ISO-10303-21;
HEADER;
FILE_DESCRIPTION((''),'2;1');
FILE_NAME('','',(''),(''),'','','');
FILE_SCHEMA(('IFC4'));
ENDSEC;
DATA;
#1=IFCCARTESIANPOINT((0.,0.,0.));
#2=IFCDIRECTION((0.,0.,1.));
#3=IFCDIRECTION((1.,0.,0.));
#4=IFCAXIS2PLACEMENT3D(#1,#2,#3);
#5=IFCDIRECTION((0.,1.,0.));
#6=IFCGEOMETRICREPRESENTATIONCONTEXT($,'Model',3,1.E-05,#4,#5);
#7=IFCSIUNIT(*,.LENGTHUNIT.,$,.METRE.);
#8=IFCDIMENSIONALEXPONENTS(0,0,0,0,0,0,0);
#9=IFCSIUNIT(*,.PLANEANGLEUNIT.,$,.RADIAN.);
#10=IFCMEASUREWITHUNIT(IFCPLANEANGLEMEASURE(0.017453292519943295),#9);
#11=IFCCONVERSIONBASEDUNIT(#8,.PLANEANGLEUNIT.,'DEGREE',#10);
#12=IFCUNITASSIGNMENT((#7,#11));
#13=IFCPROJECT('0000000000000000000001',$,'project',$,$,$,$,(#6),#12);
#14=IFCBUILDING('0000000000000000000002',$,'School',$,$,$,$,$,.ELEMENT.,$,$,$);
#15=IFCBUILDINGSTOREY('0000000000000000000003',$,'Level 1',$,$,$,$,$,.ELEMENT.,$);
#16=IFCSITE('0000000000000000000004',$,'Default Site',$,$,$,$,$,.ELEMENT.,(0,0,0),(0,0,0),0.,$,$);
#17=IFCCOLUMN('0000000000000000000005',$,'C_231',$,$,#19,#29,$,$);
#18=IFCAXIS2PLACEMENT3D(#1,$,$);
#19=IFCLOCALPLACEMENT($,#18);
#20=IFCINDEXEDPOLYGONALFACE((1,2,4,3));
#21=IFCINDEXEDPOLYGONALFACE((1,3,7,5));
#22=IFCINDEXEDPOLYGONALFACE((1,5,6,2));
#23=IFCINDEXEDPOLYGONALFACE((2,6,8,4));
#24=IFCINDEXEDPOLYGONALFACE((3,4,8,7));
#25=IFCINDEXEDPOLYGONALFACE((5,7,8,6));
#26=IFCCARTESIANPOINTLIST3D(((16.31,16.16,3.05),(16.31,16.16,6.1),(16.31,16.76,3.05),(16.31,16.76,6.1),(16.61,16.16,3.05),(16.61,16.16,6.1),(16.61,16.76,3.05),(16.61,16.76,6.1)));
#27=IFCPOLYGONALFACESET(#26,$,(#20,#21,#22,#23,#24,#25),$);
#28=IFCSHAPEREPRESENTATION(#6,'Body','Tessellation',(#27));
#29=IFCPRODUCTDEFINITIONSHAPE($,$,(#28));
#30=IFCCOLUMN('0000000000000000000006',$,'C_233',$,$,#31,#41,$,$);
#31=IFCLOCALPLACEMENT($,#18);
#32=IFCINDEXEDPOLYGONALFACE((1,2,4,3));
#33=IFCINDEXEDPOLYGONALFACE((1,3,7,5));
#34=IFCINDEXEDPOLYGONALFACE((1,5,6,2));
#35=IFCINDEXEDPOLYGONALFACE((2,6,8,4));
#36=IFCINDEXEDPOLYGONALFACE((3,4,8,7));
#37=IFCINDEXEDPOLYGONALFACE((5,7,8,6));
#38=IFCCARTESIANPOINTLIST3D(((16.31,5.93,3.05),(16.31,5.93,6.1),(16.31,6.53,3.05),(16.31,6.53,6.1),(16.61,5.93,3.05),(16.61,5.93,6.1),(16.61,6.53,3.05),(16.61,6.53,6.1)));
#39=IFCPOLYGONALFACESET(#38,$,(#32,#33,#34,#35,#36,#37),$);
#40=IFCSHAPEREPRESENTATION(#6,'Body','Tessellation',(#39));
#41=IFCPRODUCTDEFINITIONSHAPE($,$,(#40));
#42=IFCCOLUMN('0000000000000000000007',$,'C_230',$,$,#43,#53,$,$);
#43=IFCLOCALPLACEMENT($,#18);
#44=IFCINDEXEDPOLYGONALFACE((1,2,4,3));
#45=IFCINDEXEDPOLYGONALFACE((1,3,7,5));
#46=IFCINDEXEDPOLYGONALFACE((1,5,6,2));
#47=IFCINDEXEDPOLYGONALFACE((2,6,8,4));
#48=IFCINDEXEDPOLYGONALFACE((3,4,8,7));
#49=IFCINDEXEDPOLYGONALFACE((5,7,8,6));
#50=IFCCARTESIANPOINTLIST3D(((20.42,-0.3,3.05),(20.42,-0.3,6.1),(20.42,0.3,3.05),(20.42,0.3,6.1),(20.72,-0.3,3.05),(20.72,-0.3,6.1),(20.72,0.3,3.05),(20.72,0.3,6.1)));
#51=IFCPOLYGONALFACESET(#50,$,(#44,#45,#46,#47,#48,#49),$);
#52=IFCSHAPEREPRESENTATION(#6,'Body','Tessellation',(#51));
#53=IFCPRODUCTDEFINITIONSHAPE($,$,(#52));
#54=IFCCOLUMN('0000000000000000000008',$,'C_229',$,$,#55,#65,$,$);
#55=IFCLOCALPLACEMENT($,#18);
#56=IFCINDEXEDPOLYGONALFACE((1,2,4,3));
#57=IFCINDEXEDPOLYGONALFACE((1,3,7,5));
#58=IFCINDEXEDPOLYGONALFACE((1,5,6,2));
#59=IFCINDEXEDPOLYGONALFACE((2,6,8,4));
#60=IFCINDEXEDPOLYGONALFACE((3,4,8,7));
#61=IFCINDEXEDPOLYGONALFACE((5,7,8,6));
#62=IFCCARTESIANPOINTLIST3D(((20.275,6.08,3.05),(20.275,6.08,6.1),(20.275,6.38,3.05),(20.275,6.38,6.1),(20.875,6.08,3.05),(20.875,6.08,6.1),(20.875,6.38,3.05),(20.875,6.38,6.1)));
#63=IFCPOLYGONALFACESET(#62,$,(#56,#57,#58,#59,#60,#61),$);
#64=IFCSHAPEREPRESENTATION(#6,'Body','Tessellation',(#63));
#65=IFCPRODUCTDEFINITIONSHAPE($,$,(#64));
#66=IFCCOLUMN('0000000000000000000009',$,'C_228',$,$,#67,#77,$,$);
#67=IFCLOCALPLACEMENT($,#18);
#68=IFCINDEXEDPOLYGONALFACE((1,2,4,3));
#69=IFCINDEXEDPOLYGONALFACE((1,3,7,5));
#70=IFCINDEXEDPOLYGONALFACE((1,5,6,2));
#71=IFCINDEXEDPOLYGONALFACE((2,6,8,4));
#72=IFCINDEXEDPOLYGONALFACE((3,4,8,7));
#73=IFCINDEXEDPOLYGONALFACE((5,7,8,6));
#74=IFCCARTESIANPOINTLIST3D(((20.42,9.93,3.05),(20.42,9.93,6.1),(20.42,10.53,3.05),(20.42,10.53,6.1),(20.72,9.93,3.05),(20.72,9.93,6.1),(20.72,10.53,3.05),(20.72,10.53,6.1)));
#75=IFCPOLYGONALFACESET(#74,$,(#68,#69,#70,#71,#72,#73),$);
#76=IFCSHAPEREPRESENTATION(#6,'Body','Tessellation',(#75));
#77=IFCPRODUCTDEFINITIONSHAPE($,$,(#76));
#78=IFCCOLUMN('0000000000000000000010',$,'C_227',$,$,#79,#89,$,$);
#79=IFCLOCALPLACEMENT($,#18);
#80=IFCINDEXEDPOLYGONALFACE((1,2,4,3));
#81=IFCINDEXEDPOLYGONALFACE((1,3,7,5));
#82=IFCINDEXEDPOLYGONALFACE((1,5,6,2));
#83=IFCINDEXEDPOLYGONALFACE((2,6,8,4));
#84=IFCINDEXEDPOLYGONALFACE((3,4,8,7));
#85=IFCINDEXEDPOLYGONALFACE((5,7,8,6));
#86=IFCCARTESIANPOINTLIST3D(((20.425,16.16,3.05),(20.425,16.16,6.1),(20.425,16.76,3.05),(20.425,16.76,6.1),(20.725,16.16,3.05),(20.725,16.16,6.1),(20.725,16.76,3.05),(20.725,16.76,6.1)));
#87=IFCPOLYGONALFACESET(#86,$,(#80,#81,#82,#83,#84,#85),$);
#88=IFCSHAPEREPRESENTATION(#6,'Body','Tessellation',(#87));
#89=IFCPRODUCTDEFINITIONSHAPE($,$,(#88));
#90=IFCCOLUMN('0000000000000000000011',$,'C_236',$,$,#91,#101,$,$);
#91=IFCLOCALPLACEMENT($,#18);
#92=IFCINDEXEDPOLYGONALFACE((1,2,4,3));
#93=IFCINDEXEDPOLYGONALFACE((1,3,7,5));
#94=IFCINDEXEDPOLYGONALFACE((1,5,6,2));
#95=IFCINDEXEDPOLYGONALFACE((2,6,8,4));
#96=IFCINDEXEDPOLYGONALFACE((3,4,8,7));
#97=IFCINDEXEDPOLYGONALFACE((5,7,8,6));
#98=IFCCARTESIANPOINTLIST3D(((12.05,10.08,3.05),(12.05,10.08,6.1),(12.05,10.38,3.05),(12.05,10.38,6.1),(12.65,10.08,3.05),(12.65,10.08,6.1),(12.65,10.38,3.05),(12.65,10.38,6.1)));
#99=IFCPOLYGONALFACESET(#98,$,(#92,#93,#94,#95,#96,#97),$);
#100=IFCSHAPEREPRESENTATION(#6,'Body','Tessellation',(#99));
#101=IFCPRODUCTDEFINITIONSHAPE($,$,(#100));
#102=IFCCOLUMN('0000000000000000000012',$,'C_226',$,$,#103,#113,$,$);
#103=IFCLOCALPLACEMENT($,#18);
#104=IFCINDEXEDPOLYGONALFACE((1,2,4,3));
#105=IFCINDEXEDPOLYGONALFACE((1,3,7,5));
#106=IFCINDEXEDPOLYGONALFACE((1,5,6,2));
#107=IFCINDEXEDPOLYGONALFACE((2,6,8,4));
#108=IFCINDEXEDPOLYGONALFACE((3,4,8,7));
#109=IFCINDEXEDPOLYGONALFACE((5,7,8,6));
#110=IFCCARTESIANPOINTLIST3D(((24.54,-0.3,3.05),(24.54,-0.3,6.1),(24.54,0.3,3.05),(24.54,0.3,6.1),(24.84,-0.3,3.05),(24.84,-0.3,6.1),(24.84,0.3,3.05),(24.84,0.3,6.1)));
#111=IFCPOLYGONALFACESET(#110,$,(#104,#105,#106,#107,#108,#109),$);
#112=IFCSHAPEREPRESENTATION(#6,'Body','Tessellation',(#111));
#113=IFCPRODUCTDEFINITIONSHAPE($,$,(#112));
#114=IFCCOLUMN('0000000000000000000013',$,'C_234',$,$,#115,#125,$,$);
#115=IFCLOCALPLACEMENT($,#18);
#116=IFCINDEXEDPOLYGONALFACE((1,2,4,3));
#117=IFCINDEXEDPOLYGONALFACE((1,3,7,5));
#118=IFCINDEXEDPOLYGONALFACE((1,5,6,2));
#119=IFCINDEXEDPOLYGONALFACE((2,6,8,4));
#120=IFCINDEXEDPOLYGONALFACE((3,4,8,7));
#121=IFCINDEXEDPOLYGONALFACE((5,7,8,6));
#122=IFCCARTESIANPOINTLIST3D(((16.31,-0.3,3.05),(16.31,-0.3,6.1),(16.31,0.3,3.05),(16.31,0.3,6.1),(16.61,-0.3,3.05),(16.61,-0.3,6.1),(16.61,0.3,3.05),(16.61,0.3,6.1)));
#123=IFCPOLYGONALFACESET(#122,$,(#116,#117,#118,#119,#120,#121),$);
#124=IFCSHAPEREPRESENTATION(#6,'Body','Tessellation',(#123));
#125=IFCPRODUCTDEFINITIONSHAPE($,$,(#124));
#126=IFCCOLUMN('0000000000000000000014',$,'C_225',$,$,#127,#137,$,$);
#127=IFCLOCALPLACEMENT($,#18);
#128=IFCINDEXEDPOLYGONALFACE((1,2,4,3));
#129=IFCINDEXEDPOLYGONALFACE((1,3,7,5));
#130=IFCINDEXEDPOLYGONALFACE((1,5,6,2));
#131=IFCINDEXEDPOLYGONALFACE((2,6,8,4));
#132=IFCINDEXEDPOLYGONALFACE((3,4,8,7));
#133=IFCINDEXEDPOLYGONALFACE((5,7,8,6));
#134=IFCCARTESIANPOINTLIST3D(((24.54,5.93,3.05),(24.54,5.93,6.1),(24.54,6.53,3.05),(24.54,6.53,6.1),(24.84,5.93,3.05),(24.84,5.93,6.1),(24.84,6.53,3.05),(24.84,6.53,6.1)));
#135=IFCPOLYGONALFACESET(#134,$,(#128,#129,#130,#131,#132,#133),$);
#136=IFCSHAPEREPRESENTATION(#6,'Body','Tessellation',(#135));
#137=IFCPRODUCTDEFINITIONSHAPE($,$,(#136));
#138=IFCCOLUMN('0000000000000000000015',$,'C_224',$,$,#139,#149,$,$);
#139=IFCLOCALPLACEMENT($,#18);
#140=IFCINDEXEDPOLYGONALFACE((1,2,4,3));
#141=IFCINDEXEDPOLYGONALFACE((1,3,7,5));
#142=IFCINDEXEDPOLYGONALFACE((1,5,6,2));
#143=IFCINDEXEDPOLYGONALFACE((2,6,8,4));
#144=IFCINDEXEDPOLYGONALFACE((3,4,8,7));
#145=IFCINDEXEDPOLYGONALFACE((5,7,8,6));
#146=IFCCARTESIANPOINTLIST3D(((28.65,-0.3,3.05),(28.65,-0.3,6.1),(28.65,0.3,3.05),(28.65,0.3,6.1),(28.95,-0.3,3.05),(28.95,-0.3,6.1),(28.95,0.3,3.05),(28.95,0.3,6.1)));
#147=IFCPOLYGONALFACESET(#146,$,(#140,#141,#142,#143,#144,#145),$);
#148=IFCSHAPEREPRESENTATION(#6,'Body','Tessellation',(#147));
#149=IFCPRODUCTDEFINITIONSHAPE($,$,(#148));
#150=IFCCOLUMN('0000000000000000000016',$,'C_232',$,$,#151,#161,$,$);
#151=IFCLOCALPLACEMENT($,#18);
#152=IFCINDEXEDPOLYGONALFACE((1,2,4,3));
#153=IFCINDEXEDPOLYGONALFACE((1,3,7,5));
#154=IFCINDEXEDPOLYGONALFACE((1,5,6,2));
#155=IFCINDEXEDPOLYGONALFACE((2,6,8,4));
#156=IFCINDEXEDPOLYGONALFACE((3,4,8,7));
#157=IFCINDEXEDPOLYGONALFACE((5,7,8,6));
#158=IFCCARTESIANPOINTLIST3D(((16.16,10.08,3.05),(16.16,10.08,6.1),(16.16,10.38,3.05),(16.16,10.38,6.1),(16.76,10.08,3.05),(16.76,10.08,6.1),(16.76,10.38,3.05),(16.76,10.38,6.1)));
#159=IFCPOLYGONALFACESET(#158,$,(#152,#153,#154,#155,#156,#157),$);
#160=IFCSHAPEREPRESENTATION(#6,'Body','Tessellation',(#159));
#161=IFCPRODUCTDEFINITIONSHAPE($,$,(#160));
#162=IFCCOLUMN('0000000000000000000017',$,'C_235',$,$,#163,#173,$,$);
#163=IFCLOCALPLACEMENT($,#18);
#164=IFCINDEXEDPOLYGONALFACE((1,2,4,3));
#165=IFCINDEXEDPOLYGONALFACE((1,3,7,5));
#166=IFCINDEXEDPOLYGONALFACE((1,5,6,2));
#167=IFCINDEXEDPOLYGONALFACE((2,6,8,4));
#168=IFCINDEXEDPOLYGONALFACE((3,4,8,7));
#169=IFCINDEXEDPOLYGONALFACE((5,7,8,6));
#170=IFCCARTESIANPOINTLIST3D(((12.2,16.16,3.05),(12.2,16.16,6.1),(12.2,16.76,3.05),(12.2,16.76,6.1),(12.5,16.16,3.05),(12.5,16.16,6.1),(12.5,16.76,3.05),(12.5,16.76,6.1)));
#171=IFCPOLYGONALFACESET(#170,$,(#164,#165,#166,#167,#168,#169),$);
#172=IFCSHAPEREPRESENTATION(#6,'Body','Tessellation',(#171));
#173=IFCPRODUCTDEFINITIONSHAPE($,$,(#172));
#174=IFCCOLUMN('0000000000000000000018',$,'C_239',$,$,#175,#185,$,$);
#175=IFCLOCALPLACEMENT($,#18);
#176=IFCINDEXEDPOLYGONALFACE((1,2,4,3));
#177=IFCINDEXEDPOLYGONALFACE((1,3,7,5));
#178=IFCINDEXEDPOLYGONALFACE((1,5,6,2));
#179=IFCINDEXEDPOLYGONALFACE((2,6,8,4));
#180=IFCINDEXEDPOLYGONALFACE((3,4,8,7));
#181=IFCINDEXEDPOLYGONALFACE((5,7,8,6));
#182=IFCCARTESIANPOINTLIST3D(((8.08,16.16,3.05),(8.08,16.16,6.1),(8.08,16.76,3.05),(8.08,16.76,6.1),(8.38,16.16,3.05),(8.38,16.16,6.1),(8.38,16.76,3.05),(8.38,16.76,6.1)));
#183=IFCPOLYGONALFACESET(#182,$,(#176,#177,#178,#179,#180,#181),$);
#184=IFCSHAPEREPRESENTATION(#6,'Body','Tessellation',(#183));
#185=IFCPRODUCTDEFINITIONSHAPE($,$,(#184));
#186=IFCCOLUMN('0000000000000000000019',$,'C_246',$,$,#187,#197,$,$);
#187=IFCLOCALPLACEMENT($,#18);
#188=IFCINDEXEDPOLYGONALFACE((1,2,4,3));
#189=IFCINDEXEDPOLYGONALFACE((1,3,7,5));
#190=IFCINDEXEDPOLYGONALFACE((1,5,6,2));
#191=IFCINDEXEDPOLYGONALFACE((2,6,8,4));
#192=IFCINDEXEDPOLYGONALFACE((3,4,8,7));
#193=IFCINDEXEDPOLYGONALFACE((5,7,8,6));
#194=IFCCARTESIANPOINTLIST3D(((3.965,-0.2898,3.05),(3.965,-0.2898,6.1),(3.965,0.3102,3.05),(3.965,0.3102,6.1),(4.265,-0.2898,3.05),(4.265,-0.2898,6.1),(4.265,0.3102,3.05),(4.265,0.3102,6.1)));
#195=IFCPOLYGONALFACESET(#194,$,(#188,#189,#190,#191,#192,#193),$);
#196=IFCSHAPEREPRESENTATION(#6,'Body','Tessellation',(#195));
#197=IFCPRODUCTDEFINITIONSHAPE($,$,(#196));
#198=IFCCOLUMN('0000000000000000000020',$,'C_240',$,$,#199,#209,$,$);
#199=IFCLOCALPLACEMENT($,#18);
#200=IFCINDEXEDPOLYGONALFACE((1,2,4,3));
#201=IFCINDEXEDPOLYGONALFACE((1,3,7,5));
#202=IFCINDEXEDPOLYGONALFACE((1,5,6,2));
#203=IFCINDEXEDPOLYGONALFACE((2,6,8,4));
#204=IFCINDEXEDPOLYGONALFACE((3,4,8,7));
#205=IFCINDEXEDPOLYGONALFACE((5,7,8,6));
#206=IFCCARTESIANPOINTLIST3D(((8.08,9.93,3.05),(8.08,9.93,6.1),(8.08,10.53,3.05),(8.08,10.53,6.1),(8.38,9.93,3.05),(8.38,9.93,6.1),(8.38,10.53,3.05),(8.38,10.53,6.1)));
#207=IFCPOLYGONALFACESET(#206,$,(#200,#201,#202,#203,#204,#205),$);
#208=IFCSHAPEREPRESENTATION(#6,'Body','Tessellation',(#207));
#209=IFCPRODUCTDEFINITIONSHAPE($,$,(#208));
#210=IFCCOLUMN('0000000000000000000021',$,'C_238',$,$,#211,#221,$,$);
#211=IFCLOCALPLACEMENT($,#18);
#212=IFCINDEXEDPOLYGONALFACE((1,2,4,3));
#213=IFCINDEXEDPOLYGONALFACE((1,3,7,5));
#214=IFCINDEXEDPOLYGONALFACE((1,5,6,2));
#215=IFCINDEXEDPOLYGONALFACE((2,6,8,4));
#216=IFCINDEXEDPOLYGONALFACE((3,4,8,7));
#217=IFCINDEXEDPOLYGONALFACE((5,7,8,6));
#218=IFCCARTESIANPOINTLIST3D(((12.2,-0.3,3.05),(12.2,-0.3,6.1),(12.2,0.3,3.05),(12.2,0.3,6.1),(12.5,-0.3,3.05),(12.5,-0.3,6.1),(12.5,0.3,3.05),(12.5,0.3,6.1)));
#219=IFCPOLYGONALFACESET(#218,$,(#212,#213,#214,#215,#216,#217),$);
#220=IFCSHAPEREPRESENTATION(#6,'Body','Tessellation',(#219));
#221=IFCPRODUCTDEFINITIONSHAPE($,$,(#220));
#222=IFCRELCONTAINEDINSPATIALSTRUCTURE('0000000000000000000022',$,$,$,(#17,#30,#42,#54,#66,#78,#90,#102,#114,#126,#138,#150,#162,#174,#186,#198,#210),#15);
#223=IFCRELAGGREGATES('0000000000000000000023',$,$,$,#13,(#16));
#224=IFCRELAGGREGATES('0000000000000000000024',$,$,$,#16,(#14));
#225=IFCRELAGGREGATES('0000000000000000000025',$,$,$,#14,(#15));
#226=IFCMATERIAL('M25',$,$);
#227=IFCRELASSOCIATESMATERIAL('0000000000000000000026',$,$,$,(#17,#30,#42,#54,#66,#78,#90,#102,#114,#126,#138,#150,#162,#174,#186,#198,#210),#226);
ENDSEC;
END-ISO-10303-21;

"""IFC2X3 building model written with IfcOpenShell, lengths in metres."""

from ifc_helpers import new_model, entity, si_unit, converted_unit, direction, frame, frame_2d, origin_with_axes, place, context, project, spatial, rectangle, extrude, material, element, save


model = new_model("IFC2X3")

# Units and contexts
model_context = context("Model", 3, precision=1e-05, world=origin_with_axes(), true_north=direction((0.0, 1.0, 0.0)))
ifc_project = project(units=[si_unit("LENGTHUNIT", "METRE"), converted_unit("PLANEANGLEUNIT", "DEGREE", entity("IfcPlaneAngleMeasure", 0.017453292519943295), si_unit("PLANEANGLEUNIT", "RADIAN"), dimensions=[0, 0, 0, 0, 0, 0, 0])], contexts=[model_context])

# Site, building, storey
site = spatial("IfcSite", under=ifc_project, Name="Default Site", CompositionType="ELEMENT", RefLatitude=(0, 0, 0), RefLongitude=(0, 0, 0), RefElevation=0.0)
building = spatial("IfcBuilding", under=site, Name="School", CompositionType="ELEMENT")
storey = spatial("IfcBuildingStorey", under=building, Name="Level 1", CompositionType="ELEMENT")

# Columns
ifc_material = material(Name="M25")
placement = place(None, origin_with_axes())
element("IfcColumn", 1, at=placement, inside=storey, material=ifc_material, Name="C_231", context=model_context, shape_type="SweptSolid", body=[
    extrude(rectangle(XDim=0.3, YDim=0.6, at=frame_2d((0.0, 0.0), x_axis=(1.0, 0.0, 0.0))), frame((16.46, 16.46, 3.05), z_axis=(0.0, 0.0, 1.0), x_axis=(1.0, 0.0, 0.0)), (0.0, 0.0, 1.0), 3.05),
])
element("IfcColumn", 2, at=placement, inside=storey, material=ifc_material, Name="C_233", context=model_context, shape_type="SweptSolid", body=[
    extrude(rectangle(XDim=0.3, YDim=0.6, at=frame_2d((0.0, 0.0), x_axis=(1.0, 0.0, 0.0))), frame((16.46, 6.23, 3.05), z_axis=(0.0, 0.0, 1.0), x_axis=(1.0, 0.0, 0.0)), (0.0, 0.0, 1.0), 3.05),
])
element("IfcColumn", 3, at=placement, inside=storey, material=ifc_material, Name="C_230", context=model_context, shape_type="SweptSolid", body=[
    extrude(rectangle(XDim=0.3, YDim=0.6, at=frame_2d((0.0, 0.0), x_axis=(1.0, 0.0, 0.0))), frame((20.57, 0.0, 3.05), z_axis=(0.0, 0.0, 1.0), x_axis=(1.0, 0.0, 0.0)), (0.0, 0.0, 1.0), 3.05),
])
element("IfcColumn", 4, at=placement, inside=storey, material=ifc_material, Name="C_229", context=model_context, shape_type="SweptSolid", body=[
    extrude(rectangle(XDim=0.6, YDim=0.3, at=frame_2d((0.0, 0.0), x_axis=(1.0, 0.0, 0.0))), frame((20.575, 6.23, 3.05), z_axis=(0.0, 0.0, 1.0), x_axis=(1.0, 0.0, 0.0)), (0.0, 0.0, 1.0), 3.05),
])
element("IfcColumn", 5, at=placement, inside=storey, material=ifc_material, Name="C_228", context=model_context, shape_type="SweptSolid", body=[
    extrude(rectangle(XDim=0.3, YDim=0.6, at=frame_2d((0.0, 0.0), x_axis=(1.0, 0.0, 0.0))), frame((20.57, 10.23, 3.05), z_axis=(0.0, 0.0, 1.0), x_axis=(1.0, 0.0, 0.0)), (0.0, 0.0, 1.0), 3.05),
])
element("IfcColumn", 6, at=placement, inside=storey, material=ifc_material, Name="C_227", context=model_context, shape_type="SweptSolid", body=[
    extrude(rectangle(XDim=0.3, YDim=0.6, at=frame_2d((0.0, 0.0), x_axis=(1.0, 0.0, 0.0))), frame((20.575, 16.46, 3.05), z_axis=(0.0, 0.0, 1.0), x_axis=(1.0, 0.0, 0.0)), (0.0, 0.0, 1.0), 3.05),
])
element("IfcColumn", 7, at=placement, inside=storey, material=ifc_material, Name="C_236", context=model_context, shape_type="SweptSolid", body=[
    extrude(rectangle(XDim=0.6, YDim=0.3, at=frame_2d((0.0, 0.0), x_axis=(1.0, 0.0, 0.0))), frame((12.35, 10.23, 3.05), z_axis=(0.0, 0.0, 1.0), x_axis=(1.0, 0.0, 0.0)), (0.0, 0.0, 1.0), 3.05),
])
element("IfcColumn", 8, at=placement, inside=storey, material=ifc_material, Name="C_226", context=model_context, shape_type="SweptSolid", body=[
    extrude(rectangle(XDim=0.3, YDim=0.6, at=frame_2d((0.0, 0.0), x_axis=(1.0, 0.0, 0.0))), frame((24.69, 0.0, 3.05), z_axis=(0.0, 0.0, 1.0), x_axis=(1.0, 0.0, 0.0)), (0.0, 0.0, 1.0), 3.05),
])
element("IfcColumn", 9, at=placement, inside=storey, material=ifc_material, Name="C_234", context=model_context, shape_type="SweptSolid", body=[
    extrude(rectangle(XDim=0.3, YDim=0.6, at=frame_2d((0.0, 0.0), x_axis=(1.0, 0.0, 0.0))), frame((16.46, 0.0, 3.05), z_axis=(0.0, 0.0, 1.0), x_axis=(1.0, 0.0, 0.0)), (0.0, 0.0, 1.0), 3.05),
])
element("IfcColumn", 10, at=placement, inside=storey, material=ifc_material, Name="C_225", context=model_context, shape_type="SweptSolid", body=[
    extrude(rectangle(XDim=0.3, YDim=0.6, at=frame_2d((0.0, 0.0), x_axis=(1.0, 0.0, 0.0))), frame((24.69, 6.23, 3.05), z_axis=(0.0, 0.0, 1.0), x_axis=(1.0, 0.0, 0.0)), (0.0, 0.0, 1.0), 3.05),
])
element("IfcColumn", 11, at=placement, inside=storey, material=ifc_material, Name="C_224", context=model_context, shape_type="SweptSolid", body=[
    extrude(rectangle(XDim=0.3, YDim=0.6, at=frame_2d((0.0, 0.0), x_axis=(1.0, 0.0, 0.0))), frame((28.8, 0.0, 3.05), z_axis=(0.0, 0.0, 1.0), x_axis=(1.0, 0.0, 0.0)), (0.0, 0.0, 1.0), 3.05),
])
element("IfcColumn", 12, at=placement, inside=storey, material=ifc_material, Name="C_232", context=model_context, shape_type="SweptSolid", body=[
    extrude(rectangle(XDim=0.6, YDim=0.3, at=frame_2d((0.0, 0.0), x_axis=(1.0, 0.0, 0.0))), frame((16.46, 10.23, 3.05), z_axis=(0.0, 0.0, 1.0), x_axis=(1.0, 0.0, 0.0)), (0.0, 0.0, 1.0), 3.05),
])
element("IfcColumn", 13, at=placement, inside=storey, material=ifc_material, Name="C_235", context=model_context, shape_type="SweptSolid", body=[
    extrude(rectangle(XDim=0.3, YDim=0.6, at=frame_2d((0.0, 0.0), x_axis=(1.0, 0.0, 0.0))), frame((12.35, 16.46, 3.05), z_axis=(0.0, 0.0, 1.0), x_axis=(1.0, 0.0, 0.0)), (0.0, 0.0, 1.0), 3.05),
])
element("IfcColumn", 14, at=placement, inside=storey, material=ifc_material, Name="C_239", context=model_context, shape_type="SweptSolid", body=[
    extrude(rectangle(XDim=0.3, YDim=0.6, at=frame_2d((0.0, 0.0), x_axis=(1.0, 0.0, 0.0))), frame((8.23, 16.46, 3.05), z_axis=(0.0, 0.0, 1.0), x_axis=(1.0, 0.0, 0.0)), (0.0, 0.0, 1.0), 3.05),
])
element("IfcColumn", 15, at=placement, inside=storey, material=ifc_material, Name="C_246", context=model_context, shape_type="SweptSolid", body=[
    extrude(rectangle(XDim=0.3, YDim=0.6, at=frame_2d((0.0, 0.0), x_axis=(1.0, 0.0, 0.0))), frame((4.115, 0.0102, 3.05), z_axis=(0.0, 0.0, 1.0), x_axis=(1.0, 0.0, 0.0)), (0.0, 0.0, 1.0), 3.05),
])
element("IfcColumn", 16, at=placement, inside=storey, material=ifc_material, Name="C_240", context=model_context, shape_type="SweptSolid", body=[
    extrude(rectangle(XDim=0.3, YDim=0.6, at=frame_2d((0.0, 0.0), x_axis=(1.0, 0.0, 0.0))), frame((8.23, 10.23, 3.05), z_axis=(0.0, 0.0, 1.0), x_axis=(1.0, 0.0, 0.0)), (0.0, 0.0, 1.0), 3.05),
])
element("IfcColumn", 17, at=placement, inside=storey, material=ifc_material, Name="C_238", context=model_context, shape_type="SweptSolid", body=[
    extrude(rectangle(XDim=0.3, YDim=0.6, at=frame_2d((0.0, 0.0), x_axis=(1.0, 0.0, 0.0))), frame((12.35, 0.0, 3.05), z_axis=(0.0, 0.0, 1.0), x_axis=(1.0, 0.0, 0.0)), (0.0, 0.0, 1.0), 3.05),
])

save(model, "model.ifc")
